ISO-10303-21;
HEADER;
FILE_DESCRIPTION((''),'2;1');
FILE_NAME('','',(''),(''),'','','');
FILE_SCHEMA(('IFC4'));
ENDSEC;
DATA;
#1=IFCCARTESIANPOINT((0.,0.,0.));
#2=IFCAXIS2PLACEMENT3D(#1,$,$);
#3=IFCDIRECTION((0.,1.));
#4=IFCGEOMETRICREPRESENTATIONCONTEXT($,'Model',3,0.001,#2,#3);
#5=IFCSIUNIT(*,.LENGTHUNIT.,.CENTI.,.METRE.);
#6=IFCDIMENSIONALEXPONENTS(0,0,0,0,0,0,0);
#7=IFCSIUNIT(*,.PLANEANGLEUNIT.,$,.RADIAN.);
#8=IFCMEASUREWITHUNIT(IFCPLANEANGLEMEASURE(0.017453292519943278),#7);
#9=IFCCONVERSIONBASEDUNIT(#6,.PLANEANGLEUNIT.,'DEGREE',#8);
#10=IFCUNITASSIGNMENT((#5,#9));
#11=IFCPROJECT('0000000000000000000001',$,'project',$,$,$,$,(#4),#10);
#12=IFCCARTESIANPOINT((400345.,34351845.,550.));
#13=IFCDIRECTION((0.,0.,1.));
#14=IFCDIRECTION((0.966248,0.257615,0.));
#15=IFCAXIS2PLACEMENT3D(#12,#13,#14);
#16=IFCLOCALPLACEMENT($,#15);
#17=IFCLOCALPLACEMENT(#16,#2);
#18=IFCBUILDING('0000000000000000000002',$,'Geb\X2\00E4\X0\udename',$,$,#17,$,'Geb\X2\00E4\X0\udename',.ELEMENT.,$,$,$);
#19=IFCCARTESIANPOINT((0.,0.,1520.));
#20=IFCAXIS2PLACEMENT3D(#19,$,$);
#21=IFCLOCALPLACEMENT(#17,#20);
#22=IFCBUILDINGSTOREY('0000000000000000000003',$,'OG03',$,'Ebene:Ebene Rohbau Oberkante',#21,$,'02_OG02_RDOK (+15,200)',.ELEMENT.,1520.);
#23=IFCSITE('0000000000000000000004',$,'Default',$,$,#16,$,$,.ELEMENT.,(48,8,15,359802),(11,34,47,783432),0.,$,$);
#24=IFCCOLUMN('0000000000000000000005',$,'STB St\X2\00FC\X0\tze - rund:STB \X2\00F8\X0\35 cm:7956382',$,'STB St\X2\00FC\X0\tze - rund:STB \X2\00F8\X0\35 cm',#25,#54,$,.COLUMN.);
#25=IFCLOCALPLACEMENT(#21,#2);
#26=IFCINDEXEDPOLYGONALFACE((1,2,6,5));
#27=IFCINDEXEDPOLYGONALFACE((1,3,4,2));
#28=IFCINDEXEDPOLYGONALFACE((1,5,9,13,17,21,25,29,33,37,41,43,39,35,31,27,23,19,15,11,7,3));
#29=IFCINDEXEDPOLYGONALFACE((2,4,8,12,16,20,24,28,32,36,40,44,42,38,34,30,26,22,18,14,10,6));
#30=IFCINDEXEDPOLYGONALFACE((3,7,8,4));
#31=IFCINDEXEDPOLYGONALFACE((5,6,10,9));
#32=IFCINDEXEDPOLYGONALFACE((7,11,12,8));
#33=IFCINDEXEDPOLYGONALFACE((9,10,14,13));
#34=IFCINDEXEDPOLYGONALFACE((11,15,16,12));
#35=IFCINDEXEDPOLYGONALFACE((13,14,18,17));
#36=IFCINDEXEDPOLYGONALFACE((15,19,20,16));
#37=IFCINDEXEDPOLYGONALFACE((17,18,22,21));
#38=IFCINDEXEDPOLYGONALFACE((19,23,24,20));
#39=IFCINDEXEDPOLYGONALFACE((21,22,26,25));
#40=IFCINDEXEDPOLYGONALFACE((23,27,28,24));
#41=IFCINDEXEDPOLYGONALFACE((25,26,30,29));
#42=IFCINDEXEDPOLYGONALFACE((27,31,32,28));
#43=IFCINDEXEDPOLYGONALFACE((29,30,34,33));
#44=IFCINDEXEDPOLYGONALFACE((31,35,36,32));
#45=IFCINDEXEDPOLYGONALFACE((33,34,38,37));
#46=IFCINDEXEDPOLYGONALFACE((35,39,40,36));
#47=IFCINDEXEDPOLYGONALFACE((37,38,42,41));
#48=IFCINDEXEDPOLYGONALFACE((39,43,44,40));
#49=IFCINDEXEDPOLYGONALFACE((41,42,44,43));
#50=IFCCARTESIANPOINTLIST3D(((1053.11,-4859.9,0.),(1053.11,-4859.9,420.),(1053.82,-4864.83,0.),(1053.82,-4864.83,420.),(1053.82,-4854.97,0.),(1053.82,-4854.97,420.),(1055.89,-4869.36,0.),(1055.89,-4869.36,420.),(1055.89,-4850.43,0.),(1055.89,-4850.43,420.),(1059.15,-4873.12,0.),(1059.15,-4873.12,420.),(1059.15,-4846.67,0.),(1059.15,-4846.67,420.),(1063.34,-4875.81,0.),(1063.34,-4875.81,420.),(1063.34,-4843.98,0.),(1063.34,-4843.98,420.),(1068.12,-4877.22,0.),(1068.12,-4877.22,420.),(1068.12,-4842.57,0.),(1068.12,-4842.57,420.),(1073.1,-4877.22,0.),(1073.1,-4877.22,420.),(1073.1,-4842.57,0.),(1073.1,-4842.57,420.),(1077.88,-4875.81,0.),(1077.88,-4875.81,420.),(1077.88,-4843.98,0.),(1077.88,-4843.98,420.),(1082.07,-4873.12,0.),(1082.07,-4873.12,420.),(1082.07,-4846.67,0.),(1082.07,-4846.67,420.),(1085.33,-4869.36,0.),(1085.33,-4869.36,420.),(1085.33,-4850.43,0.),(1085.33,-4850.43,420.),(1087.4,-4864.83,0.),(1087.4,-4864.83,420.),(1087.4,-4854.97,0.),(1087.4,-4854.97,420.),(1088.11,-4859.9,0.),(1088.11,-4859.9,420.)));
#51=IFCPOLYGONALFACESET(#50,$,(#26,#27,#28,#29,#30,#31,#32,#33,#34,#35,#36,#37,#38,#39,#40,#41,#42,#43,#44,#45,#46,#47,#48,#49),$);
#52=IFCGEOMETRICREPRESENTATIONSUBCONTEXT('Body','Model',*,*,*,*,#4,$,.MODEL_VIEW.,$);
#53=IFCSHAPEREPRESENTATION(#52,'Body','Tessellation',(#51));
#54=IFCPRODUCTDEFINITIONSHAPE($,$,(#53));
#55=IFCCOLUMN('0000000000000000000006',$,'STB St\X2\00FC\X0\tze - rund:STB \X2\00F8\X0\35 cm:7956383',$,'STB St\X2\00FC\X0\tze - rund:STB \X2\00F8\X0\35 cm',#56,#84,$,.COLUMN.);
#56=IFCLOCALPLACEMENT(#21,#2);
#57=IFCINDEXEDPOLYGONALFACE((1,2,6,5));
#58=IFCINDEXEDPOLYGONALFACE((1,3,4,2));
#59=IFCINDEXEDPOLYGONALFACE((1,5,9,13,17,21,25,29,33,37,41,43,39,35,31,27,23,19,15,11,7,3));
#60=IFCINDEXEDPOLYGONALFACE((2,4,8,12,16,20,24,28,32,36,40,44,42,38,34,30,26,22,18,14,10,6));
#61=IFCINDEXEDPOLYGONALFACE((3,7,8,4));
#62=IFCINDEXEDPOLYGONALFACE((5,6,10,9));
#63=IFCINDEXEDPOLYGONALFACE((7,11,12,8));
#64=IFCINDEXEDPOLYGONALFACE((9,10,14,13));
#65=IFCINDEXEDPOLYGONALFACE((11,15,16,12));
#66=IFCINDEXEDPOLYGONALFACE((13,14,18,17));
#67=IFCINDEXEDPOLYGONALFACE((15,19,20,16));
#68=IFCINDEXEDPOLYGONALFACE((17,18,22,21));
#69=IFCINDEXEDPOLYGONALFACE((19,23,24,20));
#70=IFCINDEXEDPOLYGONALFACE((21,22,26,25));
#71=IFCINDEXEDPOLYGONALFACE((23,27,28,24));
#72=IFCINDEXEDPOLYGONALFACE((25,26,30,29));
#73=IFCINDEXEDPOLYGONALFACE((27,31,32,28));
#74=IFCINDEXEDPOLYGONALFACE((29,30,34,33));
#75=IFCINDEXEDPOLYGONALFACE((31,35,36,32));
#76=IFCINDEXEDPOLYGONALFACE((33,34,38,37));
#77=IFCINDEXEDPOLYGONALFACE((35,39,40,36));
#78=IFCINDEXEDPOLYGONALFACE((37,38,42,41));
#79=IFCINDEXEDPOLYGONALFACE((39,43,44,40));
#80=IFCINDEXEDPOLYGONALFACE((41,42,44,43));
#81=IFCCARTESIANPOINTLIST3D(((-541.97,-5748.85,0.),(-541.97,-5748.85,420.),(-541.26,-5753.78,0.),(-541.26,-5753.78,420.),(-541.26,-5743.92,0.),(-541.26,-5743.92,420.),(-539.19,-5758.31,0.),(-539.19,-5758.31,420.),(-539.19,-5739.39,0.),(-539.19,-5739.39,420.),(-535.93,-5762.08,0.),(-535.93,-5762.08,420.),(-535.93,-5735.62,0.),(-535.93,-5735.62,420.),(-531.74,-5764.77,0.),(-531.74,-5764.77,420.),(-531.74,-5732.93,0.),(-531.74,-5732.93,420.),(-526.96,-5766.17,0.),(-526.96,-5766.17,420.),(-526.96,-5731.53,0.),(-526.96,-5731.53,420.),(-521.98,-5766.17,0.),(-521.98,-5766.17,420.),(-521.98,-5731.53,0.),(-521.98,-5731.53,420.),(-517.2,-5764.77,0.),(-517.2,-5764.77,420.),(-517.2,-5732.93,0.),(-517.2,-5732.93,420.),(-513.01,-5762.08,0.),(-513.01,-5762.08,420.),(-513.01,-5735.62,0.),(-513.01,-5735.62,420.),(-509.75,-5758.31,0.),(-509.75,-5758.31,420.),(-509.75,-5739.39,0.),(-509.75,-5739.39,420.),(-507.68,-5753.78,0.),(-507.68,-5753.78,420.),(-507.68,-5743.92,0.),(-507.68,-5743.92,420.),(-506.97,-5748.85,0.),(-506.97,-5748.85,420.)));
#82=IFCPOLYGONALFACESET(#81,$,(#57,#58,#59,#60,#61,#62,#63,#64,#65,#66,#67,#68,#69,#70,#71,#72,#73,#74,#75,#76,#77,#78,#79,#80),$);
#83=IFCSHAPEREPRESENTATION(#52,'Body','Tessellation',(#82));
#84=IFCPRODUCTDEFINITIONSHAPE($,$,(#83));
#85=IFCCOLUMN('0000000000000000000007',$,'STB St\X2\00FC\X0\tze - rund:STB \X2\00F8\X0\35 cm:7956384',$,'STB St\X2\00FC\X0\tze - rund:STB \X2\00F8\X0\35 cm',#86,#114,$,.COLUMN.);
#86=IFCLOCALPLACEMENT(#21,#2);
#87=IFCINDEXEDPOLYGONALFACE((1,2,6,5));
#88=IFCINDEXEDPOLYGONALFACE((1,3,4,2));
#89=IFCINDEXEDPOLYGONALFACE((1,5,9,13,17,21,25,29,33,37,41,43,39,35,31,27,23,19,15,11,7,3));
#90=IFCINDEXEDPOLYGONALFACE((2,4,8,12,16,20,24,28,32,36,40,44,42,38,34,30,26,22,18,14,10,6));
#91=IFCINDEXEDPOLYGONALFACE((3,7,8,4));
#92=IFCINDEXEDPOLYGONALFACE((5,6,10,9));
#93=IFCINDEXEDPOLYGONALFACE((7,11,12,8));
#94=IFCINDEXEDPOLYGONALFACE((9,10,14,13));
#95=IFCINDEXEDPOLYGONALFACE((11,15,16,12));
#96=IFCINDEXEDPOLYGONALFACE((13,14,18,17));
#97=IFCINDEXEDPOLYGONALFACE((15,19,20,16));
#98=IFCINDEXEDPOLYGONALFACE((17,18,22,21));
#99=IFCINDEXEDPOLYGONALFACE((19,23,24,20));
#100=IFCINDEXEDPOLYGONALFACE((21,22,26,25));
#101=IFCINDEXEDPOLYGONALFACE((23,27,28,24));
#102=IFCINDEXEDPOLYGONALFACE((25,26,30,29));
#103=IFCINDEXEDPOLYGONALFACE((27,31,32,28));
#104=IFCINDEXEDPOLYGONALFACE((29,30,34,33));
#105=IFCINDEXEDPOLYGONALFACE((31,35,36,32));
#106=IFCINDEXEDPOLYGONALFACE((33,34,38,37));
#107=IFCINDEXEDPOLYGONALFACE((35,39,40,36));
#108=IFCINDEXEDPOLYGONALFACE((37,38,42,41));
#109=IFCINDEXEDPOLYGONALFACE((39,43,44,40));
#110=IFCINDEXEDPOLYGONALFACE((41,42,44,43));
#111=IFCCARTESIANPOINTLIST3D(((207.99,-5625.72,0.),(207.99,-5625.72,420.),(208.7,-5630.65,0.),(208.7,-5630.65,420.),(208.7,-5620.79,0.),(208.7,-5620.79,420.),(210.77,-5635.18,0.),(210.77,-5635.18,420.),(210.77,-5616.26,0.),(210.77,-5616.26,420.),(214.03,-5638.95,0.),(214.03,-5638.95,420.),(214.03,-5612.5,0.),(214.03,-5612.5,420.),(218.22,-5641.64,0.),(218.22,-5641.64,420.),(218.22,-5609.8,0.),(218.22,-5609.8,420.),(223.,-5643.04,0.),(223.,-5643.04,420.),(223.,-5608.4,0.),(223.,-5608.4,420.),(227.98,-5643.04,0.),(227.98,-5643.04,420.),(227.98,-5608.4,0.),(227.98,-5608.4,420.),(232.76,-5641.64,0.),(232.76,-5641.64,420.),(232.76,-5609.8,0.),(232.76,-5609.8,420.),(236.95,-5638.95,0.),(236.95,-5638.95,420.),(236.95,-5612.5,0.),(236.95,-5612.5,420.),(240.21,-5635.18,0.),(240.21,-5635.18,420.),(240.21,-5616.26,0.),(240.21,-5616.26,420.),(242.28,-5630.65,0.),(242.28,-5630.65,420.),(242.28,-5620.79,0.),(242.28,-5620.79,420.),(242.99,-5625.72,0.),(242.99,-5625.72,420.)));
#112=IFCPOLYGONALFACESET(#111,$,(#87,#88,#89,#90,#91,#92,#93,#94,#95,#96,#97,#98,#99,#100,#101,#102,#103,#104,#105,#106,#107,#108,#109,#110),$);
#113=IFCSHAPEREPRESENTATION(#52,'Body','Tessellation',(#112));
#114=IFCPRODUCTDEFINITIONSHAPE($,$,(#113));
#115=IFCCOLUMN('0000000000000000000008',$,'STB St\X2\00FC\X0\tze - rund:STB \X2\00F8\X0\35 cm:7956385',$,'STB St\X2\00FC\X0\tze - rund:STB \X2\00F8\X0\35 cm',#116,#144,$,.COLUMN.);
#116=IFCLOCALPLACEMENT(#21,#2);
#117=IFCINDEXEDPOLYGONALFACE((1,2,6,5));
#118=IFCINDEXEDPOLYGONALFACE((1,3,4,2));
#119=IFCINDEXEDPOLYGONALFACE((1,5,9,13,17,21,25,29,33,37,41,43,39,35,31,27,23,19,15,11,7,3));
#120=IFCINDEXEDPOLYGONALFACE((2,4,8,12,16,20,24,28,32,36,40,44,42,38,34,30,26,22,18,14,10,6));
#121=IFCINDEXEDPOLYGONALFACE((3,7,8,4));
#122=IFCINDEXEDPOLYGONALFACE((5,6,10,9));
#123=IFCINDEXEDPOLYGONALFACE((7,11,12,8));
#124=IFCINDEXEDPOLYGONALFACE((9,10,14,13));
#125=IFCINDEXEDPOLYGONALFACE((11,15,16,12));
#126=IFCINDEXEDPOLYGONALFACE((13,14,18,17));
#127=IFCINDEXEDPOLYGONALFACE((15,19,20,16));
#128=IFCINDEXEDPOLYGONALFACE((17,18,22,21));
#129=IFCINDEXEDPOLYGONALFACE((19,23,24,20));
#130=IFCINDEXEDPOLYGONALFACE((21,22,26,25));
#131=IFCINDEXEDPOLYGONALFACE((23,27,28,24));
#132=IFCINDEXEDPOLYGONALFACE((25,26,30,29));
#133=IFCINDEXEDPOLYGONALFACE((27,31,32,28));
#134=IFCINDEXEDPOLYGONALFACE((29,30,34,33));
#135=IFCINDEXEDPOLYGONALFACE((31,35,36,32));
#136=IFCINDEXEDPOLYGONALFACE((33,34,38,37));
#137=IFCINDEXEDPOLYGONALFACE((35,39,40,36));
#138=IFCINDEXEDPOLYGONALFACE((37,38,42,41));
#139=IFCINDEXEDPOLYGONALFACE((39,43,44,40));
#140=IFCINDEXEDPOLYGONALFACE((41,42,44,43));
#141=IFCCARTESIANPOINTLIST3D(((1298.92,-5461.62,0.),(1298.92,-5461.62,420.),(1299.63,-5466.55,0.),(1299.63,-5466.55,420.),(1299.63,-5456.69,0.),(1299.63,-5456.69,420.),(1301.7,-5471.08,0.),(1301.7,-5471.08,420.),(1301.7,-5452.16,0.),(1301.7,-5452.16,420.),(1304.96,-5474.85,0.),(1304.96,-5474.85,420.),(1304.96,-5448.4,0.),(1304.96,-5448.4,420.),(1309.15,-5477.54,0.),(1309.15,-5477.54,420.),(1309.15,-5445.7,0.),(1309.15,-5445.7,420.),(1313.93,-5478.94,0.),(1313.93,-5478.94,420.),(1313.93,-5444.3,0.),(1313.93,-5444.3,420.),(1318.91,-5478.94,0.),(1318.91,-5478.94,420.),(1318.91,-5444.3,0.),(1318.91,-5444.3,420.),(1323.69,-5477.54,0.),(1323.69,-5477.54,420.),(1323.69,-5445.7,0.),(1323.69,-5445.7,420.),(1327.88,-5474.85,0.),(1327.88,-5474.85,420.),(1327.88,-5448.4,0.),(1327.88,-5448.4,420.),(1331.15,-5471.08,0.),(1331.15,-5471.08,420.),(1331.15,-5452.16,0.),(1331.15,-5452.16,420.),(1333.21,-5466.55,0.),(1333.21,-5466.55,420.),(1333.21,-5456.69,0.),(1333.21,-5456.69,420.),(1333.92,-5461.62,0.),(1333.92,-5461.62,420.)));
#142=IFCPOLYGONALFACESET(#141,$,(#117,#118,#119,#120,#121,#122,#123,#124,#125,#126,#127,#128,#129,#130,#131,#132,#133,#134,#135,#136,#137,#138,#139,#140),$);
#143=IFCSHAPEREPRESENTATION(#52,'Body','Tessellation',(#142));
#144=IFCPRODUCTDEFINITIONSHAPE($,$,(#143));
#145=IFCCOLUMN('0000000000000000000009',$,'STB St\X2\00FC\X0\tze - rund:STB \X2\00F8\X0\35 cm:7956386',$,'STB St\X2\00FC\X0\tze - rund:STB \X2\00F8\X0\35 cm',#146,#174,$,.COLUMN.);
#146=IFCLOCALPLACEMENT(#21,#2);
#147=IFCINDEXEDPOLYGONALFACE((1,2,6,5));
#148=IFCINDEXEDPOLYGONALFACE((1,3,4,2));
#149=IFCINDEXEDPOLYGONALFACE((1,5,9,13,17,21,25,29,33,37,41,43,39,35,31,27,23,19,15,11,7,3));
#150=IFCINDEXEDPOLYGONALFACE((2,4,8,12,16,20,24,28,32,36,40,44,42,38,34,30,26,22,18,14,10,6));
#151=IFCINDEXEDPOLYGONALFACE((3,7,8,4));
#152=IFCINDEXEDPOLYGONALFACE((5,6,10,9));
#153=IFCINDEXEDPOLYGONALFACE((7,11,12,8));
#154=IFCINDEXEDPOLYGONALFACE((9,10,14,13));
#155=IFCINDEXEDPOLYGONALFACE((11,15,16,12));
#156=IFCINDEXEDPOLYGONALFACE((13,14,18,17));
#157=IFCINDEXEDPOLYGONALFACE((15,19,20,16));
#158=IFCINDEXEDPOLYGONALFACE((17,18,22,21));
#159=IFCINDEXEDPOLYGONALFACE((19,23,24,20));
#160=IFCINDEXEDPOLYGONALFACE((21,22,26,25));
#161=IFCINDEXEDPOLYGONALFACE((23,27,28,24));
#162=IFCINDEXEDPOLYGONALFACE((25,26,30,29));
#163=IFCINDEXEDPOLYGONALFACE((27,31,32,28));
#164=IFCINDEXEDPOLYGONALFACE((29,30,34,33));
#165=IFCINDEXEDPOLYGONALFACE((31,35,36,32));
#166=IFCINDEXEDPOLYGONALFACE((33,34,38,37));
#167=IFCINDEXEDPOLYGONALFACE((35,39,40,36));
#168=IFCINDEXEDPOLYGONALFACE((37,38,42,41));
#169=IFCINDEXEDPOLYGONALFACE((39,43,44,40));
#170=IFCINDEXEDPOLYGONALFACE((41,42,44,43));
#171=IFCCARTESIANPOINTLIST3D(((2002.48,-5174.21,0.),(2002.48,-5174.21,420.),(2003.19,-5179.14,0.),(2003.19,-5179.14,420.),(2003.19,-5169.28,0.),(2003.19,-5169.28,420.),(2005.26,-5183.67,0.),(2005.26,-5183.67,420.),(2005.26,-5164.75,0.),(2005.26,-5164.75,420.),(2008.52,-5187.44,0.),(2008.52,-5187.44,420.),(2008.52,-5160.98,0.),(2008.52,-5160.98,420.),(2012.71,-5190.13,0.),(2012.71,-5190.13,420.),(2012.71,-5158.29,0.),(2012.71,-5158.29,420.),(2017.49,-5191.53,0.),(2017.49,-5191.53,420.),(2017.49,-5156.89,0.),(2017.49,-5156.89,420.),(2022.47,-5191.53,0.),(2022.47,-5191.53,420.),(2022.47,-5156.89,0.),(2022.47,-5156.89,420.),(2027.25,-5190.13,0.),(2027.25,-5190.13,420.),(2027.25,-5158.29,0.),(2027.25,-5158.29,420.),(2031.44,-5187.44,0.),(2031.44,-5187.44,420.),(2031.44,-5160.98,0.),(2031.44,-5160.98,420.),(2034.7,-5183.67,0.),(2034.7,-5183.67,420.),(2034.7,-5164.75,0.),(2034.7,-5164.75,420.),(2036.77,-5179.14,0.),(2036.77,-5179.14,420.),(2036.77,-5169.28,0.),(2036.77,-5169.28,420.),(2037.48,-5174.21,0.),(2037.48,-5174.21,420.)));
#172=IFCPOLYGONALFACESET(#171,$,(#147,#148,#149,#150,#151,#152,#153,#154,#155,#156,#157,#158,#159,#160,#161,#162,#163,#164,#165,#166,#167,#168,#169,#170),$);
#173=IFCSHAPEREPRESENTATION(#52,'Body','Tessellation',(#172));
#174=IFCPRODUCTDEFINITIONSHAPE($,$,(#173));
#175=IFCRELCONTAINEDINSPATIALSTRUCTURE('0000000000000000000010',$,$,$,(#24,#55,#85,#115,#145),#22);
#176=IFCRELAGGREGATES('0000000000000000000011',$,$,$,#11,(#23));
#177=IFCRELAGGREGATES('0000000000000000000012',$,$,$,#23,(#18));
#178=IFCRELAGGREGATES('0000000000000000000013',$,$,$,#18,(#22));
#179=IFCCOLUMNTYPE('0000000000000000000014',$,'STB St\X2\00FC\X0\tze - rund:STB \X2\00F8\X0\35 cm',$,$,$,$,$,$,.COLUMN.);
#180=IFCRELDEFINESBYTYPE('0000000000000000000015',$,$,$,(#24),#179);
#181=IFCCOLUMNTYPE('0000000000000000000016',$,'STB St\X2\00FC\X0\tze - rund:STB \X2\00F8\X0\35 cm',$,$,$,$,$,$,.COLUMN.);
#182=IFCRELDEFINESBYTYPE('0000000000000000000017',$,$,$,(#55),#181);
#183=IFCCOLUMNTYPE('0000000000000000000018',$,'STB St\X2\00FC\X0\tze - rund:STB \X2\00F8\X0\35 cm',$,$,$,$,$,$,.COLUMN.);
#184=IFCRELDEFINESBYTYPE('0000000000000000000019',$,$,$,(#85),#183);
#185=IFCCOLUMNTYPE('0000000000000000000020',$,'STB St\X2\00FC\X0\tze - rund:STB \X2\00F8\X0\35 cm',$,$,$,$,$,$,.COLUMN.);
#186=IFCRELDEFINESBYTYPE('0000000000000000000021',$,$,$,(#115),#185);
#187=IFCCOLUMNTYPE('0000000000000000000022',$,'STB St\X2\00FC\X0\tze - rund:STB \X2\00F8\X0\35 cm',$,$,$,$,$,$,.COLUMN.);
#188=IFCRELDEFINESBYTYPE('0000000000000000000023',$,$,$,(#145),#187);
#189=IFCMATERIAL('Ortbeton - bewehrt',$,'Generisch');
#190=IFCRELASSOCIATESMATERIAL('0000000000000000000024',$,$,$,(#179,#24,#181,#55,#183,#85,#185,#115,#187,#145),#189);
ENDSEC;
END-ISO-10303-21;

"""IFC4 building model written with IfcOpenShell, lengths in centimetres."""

from ifc_helpers import new_model, entity, si_unit, converted_unit, direction, frame, origin, place, context, subcontext, project, spatial, arc, indexed_curve, outline, extrude, source, transform, mapped, material, type_object, type_shapes, element, save


model = new_model("IFC4")

# Units and contexts
model_context = context("Model", 3, precision=0.001, world=origin(), true_north=direction((0.0, 1.0)))
body_context = subcontext(model_context, "Body", "Model", "MODEL_VIEW")
ifc_project = project(units=[si_unit("LENGTHUNIT", "METRE", prefix="CENTI"), converted_unit("PLANEANGLEUNIT", "DEGREE", entity("IfcPlaneAngleMeasure", 0.017453292519943278), si_unit("PLANEANGLEUNIT", "RADIAN"), dimensions=[0, 0, 0, 0, 0, 0, 0])], contexts=[model_context])

# Site, building, storey
site_placement = place(None, frame((400345.0, 34351845.0, 550.0), z_axis=(0.0, 0.0, 1.0), x_axis=(0.966248, 0.257615, 0.0)))
site = spatial("IfcSite", under=ifc_project, at=site_placement, Name="Default", CompositionType="ELEMENT", RefLatitude=(48, 8, 15, 359802), RefLongitude=(11, 34, 47, 783432), RefElevation=0.0)
building_placement = place(site_placement, origin())
building = spatial("IfcBuilding", under=site, at=building_placement, Name="Gebäudename", LongName="Gebäudename", CompositionType="ELEMENT")
storey_placement = place(building_placement, frame((0.0, 0.0, 1520.0)))
storey = spatial("IfcBuildingStorey", under=building, at=storey_placement, Name="OG03", ObjectType="Ebene:Ebene Rohbau Oberkante", LongName="02_OG02_RDOK (+15,200)", CompositionType="ELEMENT", Elevation=1520.0)

# Columns
ifc_material = material(Name="Ortbeton - bewehrt", Category="Generisch")
column_type_1 = type_object("IfcColumnType", Name="STB Stütze - rund:STB ø35 cm", PredefinedType="COLUMN", material=ifc_material)
shared_shape_1 = source(origin(), body_context, "Body", "SweptSolid", [
    extrude(outline(indexed_curve([(-17.5, 0.0), (0.0, -17.5), (17.5, 0.0), (0.0, 17.5)], segments=[arc(1, 2, 3), arc(3, 4, 1)], self_intersect=False)), frame((1070.61, -4859.9, 1520.0)), (0.0, 0.0, 1.0), 420.0),
])
type_shapes(column_type_1, [shared_shape_1])
column_1_placement = place(storey_placement, frame((0.0, 0.0, -1520.0)))
element("IfcColumn", 1, at=column_1_placement, inside=storey, type_object=column_type_1, material=ifc_material, Name="STB Stütze - rund:STB ø35 cm:7956382", ObjectType="STB Stütze - rund:STB ø35 cm", PredefinedType="COLUMN", context=body_context, shape_type="MappedRepresentation", body=[
    mapped(shared_shape_1, transform((0.0, 0.0, 0.0), scale=1.0)),
])
column_type_2 = type_object("IfcColumnType", Name="STB Stütze - rund:STB ø35 cm", PredefinedType="COLUMN", material=ifc_material)
shared_shape_2 = source(origin(), body_context, "Body", "SweptSolid", [
    extrude(outline(indexed_curve([(-17.5, 0.0), (0.0, -17.5), (17.5, 0.0), (0.0, 17.5)], segments=[arc(1, 2, 3), arc(3, 4, 1)], self_intersect=False)), frame((-524.47, -5748.85, 1520.0)), (0.0, 0.0, 1.0), 420.0),
])
type_shapes(column_type_2, [shared_shape_2])
column_2_placement = place(storey_placement, frame((0.0, 0.0, -1520.0)))
element("IfcColumn", 2, at=column_2_placement, inside=storey, type_object=column_type_2, material=ifc_material, Name="STB Stütze - rund:STB ø35 cm:7956383", ObjectType="STB Stütze - rund:STB ø35 cm", PredefinedType="COLUMN", context=body_context, shape_type="MappedRepresentation", body=[
    mapped(shared_shape_2, transform((0.0, 0.0, 0.0), scale=1.0)),
])
column_type_3 = type_object("IfcColumnType", Name="STB Stütze - rund:STB ø35 cm", PredefinedType="COLUMN", material=ifc_material)
shared_shape_3 = source(origin(), body_context, "Body", "SweptSolid", [
    extrude(outline(indexed_curve([(-17.5, 0.0), (0.0, -17.5), (17.5, 0.0), (0.0, 17.5)], segments=[arc(1, 2, 3), arc(3, 4, 1)], self_intersect=False)), frame((225.49, -5625.72, 1520.0)), (0.0, 0.0, 1.0), 420.0),
])
type_shapes(column_type_3, [shared_shape_3])
column_3_placement = place(storey_placement, frame((0.0, 0.0, -1520.0)))
element("IfcColumn", 3, at=column_3_placement, inside=storey, type_object=column_type_3, material=ifc_material, Name="STB Stütze - rund:STB ø35 cm:7956384", ObjectType="STB Stütze - rund:STB ø35 cm", PredefinedType="COLUMN", context=body_context, shape_type="MappedRepresentation", body=[
    mapped(shared_shape_3, transform((0.0, 0.0, 0.0), scale=1.0)),
])
column_type_4 = type_object("IfcColumnType", Name="STB Stütze - rund:STB ø35 cm", PredefinedType="COLUMN", material=ifc_material)
shared_shape_4 = source(origin(), body_context, "Body", "SweptSolid", [
    extrude(outline(indexed_curve([(-17.5, 0.0), (0.0, -17.5), (17.5, 0.0), (0.0, 17.5)], segments=[arc(1, 2, 3), arc(3, 4, 1)], self_intersect=False)), frame((1316.42, -5461.62, 1520.0)), (0.0, 0.0, 1.0), 420.0),
])
type_shapes(column_type_4, [shared_shape_4])
column_4_placement = place(storey_placement, frame((0.0, 0.0, -1520.0)))
element("IfcColumn", 4, at=column_4_placement, inside=storey, type_object=column_type_4, material=ifc_material, Name="STB Stütze - rund:STB ø35 cm:7956385", ObjectType="STB Stütze - rund:STB ø35 cm", PredefinedType="COLUMN", context=body_context, shape_type="MappedRepresentation", body=[
    mapped(shared_shape_4, transform((0.0, 0.0, 0.0), scale=1.0)),
])
column_type_5 = type_object("IfcColumnType", Name="STB Stütze - rund:STB ø35 cm", PredefinedType="COLUMN", material=ifc_material)
shared_shape_5 = source(origin(), body_context, "Body", "SweptSolid", [
    extrude(outline(indexed_curve([(-17.5, 0.0), (0.0, -17.5), (17.5, 0.0), (0.0, 17.5)], segments=[arc(1, 2, 3), arc(3, 4, 1)], self_intersect=False)), frame((2019.98, -5174.21, 1520.0)), (0.0, 0.0, 1.0), 420.0),
])
type_shapes(column_type_5, [shared_shape_5])
column_5_placement = place(storey_placement, frame((0.0, 0.0, -1520.0)))
element("IfcColumn", 5, at=column_5_placement, inside=storey, type_object=column_type_5, material=ifc_material, Name="STB Stütze - rund:STB ø35 cm:7956386", ObjectType="STB Stütze - rund:STB ø35 cm", PredefinedType="COLUMN", context=body_context, shape_type="MappedRepresentation", body=[
    mapped(shared_shape_5, transform((0.0, 0.0, 0.0), scale=1.0)),
])

save(model, "model.ifc")
